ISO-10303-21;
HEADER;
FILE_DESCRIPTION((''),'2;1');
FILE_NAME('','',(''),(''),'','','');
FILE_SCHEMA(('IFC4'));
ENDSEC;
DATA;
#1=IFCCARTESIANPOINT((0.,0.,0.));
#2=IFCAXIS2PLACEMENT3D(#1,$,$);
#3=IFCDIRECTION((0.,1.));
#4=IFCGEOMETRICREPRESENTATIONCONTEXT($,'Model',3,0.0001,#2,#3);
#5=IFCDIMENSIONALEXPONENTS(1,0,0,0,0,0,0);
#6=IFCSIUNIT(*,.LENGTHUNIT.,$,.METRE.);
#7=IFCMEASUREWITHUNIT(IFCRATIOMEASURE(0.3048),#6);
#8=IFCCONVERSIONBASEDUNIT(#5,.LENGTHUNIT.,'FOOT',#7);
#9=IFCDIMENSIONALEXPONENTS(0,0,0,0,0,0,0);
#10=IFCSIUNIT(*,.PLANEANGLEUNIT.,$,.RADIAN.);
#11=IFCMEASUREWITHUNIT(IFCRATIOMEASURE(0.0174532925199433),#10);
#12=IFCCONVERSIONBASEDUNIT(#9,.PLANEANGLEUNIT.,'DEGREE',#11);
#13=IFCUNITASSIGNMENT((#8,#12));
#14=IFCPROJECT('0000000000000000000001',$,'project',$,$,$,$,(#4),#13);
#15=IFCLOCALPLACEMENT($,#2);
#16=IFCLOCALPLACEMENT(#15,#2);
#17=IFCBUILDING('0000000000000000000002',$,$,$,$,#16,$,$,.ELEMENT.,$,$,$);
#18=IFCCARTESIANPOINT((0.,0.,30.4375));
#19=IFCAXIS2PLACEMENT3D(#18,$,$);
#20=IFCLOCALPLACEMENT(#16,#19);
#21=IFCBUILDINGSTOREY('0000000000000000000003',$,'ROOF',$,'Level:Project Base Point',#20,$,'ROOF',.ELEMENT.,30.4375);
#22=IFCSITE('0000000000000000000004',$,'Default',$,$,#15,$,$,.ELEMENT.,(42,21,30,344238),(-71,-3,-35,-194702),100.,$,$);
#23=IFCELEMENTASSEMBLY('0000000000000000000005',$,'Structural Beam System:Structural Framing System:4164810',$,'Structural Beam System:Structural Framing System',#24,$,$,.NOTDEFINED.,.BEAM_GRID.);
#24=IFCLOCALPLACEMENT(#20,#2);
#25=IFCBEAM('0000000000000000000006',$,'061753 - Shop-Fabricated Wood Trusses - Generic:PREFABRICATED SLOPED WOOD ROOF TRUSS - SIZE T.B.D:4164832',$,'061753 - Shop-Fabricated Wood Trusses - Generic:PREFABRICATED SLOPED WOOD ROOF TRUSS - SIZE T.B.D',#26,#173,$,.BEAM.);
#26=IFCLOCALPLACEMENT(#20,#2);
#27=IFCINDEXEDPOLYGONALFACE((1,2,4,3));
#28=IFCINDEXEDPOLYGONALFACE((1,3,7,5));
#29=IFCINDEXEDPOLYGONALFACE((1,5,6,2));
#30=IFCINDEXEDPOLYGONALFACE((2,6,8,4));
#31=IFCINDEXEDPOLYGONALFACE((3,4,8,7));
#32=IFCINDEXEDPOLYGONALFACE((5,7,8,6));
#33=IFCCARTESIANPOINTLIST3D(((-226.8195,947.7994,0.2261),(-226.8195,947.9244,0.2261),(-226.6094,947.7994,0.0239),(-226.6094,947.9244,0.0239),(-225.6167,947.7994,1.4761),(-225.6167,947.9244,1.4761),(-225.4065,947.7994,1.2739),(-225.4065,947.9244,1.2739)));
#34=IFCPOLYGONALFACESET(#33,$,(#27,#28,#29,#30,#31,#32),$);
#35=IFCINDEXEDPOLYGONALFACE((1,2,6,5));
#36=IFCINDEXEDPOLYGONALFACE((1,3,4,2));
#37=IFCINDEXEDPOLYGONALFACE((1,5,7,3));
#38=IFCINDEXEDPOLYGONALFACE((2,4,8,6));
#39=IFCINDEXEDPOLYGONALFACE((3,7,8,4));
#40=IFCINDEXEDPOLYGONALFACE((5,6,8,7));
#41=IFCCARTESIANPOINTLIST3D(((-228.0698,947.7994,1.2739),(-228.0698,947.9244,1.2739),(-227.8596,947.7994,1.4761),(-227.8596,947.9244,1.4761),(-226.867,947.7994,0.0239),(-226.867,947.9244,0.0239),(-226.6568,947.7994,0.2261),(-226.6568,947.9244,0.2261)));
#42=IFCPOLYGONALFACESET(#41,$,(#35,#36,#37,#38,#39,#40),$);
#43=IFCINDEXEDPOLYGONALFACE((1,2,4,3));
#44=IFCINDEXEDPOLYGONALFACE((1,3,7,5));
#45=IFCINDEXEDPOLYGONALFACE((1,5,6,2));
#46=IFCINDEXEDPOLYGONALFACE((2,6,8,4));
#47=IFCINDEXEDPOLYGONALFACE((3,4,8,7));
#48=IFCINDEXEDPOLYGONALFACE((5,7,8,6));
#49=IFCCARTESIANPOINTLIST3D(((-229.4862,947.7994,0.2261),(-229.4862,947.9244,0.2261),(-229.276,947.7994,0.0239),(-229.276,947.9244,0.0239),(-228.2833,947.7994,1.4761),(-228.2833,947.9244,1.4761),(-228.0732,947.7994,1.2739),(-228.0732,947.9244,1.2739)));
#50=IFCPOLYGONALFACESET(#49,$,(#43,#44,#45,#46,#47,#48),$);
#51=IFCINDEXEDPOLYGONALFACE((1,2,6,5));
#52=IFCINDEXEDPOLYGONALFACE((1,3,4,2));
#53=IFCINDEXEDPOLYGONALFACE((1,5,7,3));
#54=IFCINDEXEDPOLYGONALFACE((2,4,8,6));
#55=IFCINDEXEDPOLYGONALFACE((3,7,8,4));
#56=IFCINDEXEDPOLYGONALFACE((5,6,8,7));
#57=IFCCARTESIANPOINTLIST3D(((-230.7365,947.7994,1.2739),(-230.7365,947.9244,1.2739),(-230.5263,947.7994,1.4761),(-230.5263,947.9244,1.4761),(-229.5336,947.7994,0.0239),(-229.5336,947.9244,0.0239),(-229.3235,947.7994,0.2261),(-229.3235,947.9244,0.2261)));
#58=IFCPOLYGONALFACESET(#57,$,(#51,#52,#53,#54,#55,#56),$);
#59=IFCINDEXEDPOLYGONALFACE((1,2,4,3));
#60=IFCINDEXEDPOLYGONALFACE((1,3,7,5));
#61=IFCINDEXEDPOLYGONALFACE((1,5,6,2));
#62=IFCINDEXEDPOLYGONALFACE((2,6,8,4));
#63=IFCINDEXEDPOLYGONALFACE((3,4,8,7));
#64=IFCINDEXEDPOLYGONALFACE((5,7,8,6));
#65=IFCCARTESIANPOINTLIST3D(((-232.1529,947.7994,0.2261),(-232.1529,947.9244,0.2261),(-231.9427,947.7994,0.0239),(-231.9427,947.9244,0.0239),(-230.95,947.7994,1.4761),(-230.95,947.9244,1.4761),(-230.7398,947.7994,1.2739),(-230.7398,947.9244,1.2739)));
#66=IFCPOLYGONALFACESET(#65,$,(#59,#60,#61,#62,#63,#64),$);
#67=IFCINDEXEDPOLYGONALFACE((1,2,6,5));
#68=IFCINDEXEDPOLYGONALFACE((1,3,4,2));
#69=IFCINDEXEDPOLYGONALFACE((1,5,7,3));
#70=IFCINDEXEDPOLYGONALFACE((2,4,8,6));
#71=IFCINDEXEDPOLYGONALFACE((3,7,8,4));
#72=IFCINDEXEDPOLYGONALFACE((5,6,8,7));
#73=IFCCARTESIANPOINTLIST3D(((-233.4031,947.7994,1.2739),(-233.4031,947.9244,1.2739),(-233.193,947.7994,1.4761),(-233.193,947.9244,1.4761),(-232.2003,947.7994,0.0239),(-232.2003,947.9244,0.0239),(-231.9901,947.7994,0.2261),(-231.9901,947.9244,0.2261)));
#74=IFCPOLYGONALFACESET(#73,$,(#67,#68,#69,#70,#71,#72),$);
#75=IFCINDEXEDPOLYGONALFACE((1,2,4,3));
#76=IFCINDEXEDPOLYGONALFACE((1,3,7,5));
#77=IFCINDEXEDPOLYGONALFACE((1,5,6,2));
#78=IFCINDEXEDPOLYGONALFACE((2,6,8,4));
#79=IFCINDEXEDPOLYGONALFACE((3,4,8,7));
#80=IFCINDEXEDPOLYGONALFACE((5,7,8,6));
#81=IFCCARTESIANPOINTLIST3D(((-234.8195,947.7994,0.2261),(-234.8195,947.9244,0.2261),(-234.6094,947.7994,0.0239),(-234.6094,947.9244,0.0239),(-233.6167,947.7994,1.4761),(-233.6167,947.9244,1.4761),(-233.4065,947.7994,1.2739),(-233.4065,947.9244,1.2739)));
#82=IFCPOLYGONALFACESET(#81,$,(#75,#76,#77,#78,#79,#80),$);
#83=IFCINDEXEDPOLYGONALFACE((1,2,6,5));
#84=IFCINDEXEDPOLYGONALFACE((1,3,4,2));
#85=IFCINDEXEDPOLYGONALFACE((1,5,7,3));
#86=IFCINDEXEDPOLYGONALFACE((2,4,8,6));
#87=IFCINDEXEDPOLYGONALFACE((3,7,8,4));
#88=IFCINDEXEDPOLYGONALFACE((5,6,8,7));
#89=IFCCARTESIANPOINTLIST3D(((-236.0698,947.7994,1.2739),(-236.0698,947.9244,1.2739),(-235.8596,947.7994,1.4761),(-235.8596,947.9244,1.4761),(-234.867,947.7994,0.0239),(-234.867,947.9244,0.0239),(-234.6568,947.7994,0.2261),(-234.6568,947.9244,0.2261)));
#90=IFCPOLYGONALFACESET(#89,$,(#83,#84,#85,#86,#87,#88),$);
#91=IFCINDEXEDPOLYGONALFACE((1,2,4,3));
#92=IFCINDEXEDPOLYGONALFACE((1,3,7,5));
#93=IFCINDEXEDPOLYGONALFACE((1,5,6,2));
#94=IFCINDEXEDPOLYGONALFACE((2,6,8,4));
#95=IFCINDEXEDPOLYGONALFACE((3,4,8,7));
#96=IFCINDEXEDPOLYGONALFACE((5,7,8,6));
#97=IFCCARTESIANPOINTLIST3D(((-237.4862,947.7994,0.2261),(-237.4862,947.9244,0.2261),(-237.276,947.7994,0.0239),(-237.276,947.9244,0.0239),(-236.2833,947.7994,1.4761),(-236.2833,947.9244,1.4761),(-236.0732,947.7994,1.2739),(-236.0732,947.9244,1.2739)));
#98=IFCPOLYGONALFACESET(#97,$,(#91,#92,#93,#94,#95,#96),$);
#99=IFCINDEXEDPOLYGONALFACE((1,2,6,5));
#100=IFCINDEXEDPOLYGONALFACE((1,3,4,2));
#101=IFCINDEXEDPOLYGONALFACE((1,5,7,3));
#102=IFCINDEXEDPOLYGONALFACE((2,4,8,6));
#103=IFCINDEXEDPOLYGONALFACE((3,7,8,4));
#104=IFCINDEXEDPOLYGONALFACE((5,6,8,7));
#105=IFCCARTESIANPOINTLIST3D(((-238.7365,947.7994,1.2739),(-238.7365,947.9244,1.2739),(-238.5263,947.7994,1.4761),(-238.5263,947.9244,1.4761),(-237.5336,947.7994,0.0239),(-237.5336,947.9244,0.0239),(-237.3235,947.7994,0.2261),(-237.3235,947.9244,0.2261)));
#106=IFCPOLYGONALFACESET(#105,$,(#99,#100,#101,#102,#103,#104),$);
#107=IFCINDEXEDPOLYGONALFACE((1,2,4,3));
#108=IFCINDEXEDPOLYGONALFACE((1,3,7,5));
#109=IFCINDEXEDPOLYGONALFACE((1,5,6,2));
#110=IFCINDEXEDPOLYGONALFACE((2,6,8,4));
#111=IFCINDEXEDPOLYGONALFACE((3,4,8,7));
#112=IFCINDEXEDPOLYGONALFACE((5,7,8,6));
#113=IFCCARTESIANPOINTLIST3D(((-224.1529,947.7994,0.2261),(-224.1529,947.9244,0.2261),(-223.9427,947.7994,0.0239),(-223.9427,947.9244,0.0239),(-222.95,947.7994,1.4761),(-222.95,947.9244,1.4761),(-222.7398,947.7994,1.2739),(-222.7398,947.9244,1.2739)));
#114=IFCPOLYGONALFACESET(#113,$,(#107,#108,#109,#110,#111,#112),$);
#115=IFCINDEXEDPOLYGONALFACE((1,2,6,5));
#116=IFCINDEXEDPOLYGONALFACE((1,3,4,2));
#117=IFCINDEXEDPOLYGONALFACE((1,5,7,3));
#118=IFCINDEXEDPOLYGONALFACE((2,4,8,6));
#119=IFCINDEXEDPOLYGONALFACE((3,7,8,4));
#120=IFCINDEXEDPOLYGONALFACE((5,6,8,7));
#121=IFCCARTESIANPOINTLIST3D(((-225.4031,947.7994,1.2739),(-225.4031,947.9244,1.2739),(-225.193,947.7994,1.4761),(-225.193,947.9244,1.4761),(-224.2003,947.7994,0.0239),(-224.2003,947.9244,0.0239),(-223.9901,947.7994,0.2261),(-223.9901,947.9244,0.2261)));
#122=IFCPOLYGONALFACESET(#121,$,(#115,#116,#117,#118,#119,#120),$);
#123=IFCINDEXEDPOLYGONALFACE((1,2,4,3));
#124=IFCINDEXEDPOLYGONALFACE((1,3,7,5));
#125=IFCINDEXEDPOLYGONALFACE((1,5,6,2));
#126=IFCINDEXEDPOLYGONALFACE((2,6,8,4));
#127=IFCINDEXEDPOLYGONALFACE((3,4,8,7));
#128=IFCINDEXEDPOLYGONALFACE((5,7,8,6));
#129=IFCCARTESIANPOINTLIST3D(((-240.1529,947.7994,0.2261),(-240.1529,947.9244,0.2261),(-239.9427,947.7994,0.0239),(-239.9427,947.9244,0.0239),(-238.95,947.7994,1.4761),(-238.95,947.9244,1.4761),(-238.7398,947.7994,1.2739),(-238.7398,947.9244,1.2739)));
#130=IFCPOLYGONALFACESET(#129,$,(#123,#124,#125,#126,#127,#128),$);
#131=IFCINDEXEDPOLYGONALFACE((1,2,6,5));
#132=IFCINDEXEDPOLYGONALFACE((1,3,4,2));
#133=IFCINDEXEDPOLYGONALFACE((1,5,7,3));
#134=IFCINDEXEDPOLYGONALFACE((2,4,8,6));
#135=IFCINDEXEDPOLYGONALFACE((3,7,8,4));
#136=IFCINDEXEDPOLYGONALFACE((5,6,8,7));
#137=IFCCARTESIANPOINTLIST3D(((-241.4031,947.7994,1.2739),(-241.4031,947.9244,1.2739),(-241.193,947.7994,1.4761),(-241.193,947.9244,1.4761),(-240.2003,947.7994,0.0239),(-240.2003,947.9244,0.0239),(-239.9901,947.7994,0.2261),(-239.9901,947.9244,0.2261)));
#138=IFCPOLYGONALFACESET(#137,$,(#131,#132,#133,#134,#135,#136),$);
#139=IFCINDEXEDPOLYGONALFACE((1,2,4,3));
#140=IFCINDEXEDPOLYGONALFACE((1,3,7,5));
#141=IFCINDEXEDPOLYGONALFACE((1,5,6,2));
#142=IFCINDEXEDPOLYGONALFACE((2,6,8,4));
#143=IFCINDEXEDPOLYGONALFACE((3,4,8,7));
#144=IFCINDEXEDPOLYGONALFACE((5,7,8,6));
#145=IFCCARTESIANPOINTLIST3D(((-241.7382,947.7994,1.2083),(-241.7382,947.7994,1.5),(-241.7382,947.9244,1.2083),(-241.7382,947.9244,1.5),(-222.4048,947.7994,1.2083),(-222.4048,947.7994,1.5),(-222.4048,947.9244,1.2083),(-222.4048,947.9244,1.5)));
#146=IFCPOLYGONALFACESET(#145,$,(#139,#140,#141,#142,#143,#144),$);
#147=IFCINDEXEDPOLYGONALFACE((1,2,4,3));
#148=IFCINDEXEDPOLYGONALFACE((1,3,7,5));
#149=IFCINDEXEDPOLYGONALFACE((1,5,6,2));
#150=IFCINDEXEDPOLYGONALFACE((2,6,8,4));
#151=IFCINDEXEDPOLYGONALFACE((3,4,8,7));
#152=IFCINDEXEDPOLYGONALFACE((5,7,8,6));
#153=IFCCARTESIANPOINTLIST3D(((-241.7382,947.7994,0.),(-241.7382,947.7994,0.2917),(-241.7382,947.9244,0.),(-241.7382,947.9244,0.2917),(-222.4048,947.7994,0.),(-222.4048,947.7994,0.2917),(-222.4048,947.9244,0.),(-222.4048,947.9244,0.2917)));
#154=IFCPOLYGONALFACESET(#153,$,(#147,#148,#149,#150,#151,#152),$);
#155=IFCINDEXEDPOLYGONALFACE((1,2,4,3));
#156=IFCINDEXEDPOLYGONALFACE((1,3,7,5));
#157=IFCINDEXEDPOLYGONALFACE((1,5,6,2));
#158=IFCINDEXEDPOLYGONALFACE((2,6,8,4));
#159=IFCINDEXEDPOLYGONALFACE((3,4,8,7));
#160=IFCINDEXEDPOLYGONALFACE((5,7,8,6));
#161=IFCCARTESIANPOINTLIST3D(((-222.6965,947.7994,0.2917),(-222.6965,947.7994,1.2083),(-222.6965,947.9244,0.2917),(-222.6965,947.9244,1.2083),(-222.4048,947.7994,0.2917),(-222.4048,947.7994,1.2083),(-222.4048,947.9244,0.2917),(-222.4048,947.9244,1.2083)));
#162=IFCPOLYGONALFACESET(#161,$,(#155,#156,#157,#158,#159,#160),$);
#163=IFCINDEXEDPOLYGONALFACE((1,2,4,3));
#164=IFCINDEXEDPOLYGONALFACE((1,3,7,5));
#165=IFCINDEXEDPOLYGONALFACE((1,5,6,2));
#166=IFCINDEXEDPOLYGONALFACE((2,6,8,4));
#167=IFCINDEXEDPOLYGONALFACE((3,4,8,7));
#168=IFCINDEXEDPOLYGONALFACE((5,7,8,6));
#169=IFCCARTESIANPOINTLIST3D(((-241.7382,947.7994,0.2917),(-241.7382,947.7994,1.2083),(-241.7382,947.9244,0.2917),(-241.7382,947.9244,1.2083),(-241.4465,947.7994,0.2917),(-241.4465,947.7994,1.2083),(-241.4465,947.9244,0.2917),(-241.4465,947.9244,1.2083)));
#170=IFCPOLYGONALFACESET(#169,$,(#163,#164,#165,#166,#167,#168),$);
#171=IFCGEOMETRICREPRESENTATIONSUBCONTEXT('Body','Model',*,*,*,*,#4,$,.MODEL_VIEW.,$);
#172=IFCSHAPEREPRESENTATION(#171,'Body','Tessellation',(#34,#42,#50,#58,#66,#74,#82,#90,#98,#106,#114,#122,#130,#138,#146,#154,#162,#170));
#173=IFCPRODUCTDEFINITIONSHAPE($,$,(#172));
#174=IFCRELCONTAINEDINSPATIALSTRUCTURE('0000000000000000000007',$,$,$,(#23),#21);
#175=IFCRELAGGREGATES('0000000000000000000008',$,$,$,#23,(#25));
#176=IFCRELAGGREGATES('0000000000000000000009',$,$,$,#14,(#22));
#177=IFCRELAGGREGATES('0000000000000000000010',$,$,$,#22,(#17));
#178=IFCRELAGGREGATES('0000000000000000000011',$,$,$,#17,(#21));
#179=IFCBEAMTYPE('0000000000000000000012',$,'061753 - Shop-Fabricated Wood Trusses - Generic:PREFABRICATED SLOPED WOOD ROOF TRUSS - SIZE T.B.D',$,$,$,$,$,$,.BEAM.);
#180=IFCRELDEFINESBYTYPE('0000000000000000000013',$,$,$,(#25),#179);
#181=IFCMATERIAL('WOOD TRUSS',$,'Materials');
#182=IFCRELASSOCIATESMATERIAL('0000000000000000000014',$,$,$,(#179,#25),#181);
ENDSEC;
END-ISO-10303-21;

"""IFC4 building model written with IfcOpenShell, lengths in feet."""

from ifc_helpers import new_model, entity, si_unit, converted_unit, direction, frame, frame_2d, origin, origin_2d_with_axis, place, context, subcontext, project, spatial, rectangle, extrude, source, transform, mapped, material, material_profile, profile_set, profile_usage, type_object, type_shapes, element, aggregate, save


model = new_model("IFC4")

# Units and contexts
model_context = context("Model", 3, precision=0.0001, world=origin(), true_north=direction((0.0, 1.0)))
body_context = subcontext(model_context, "Body", "Model", "MODEL_VIEW")
ifc_project = project(units=[converted_unit("LENGTHUNIT", "FOOT", entity("IfcRatioMeasure", 0.3048), si_unit("LENGTHUNIT", "METRE"), dimensions=[1, 0, 0, 0, 0, 0, 0]), converted_unit("PLANEANGLEUNIT", "DEGREE", entity("IfcRatioMeasure", 0.0174532925199433), si_unit("PLANEANGLEUNIT", "RADIAN"), dimensions=[0, 0, 0, 0, 0, 0, 0])], contexts=[model_context])

# Site, building, storey
site_placement = place(None, origin())
site = spatial("IfcSite", under=ifc_project, at=site_placement, Name="Default", CompositionType="ELEMENT", RefLatitude=(42, 21, 30, 344238), RefLongitude=(-71, -3, -35, -194702), RefElevation=100.0)
building_placement = place(site_placement, origin())
building = spatial("IfcBuilding", under=site, at=building_placement, CompositionType="ELEMENT")
storey_placement = place(building_placement, frame((0.0, 0.0, 30.4375)))
storey = spatial("IfcBuildingStorey", under=building, at=storey_placement, Name="ROOF", ObjectType="Level:Project Base Point", LongName="ROOF", CompositionType="ELEMENT", Elevation=30.4375)

# Element assembly, beam
assembly_1_placement = place(storey_placement, origin())
assembly_1 = element("IfcElementAssembly", 1, at=assembly_1_placement, inside=storey, Name="Structural Beam System:Structural Framing System:4164810", ObjectType="Structural Beam System:Structural Framing System", AssemblyPlace="NOTDEFINED", PredefinedType="BEAM_GRID")
ifc_material_1 = material(Name="WOOD TRUSS", Category="Materials")
ifc_material_profile_1 = material_profile(ifc_material_1, rectangle(XDim=1.7347, YDim=0.125, at=origin_2d_with_axis()), Name="PREFABRICATED SLOPED WOOD ROOF TRUSS - SIZE T.B.D")
ifc_material_profile_2 = material_profile(ifc_material_1, rectangle(XDim=1.7347, YDim=0.125, at=frame_2d((0.0, 0.0), x_axis=(1.0, 0.0))), Name="PREFABRICATED SLOPED WOOD ROOF TRUSS - SIZE T.B.D")
ifc_material_profile_3 = material_profile(ifc_material_1, rectangle(XDim=1.7347, YDim=0.125, at=origin_2d_with_axis()), Name="PREFABRICATED SLOPED WOOD ROOF TRUSS - SIZE T.B.D")
ifc_material_profile_4 = material_profile(ifc_material_1, rectangle(XDim=1.7347, YDim=0.125, at=origin_2d_with_axis()), Name="PREFABRICATED SLOPED WOOD ROOF TRUSS - SIZE T.B.D")
ifc_material_profile_5 = material_profile(ifc_material_1, rectangle(XDim=1.7347, YDim=0.125, at=frame_2d((0.0, 0.0), x_axis=(1.0, 0.0))), Name="PREFABRICATED SLOPED WOOD ROOF TRUSS - SIZE T.B.D")
ifc_material_profile_6 = material_profile(ifc_material_1, rectangle(XDim=1.7347, YDim=0.125, at=frame_2d((0.0, 0.0), x_axis=(1.0, 0.0))), Name="PREFABRICATED SLOPED WOOD ROOF TRUSS - SIZE T.B.D")
ifc_material_profile_7 = material_profile(ifc_material_1, rectangle(XDim=1.7347, YDim=0.125, at=frame_2d((0.0, 0.0), x_axis=(1.0, 0.0))), Name="PREFABRICATED SLOPED WOOD ROOF TRUSS - SIZE T.B.D")
ifc_material_profile_8 = material_profile(ifc_material_1, rectangle(XDim=1.7347, YDim=0.125, at=frame_2d((0.0, 0.0), x_axis=(1.0, 0.0))), Name="PREFABRICATED SLOPED WOOD ROOF TRUSS - SIZE T.B.D")
ifc_material_profile_9 = material_profile(ifc_material_1, rectangle(XDim=1.7347, YDim=0.125, at=origin_2d_with_axis()), Name="PREFABRICATED SLOPED WOOD ROOF TRUSS - SIZE T.B.D")
ifc_material_profile_10 = material_profile(ifc_material_1, rectangle(XDim=1.7347, YDim=0.125, at=frame_2d((0.0, 0.0), x_axis=(1.0, 0.0))), Name="PREFABRICATED SLOPED WOOD ROOF TRUSS - SIZE T.B.D")
ifc_material_profile_11 = material_profile(ifc_material_1, rectangle(XDim=0.2917, YDim=0.125, at=frame_2d((0.0, 0.0), x_axis=(1.0, 0.0))), Name="PREFABRICATED SLOPED WOOD ROOF TRUSS - SIZE T.B.D")
ifc_material_profile_12 = material_profile(ifc_material_1, rectangle(XDim=0.2917, YDim=0.125, at=frame_2d((0.0, 0.0), x_axis=(1.0, 0.0))), Name="PREFABRICATED SLOPED WOOD ROOF TRUSS - SIZE T.B.D")
ifc_material_profile_13 = material_profile(ifc_material_1, rectangle(XDim=0.9167, YDim=0.125, at=frame_2d((0.0, 0.0), x_axis=(1.0, 0.0))), Name="PREFABRICATED SLOPED WOOD ROOF TRUSS - SIZE T.B.D")
ifc_material_profile_14 = material_profile(ifc_material_1, rectangle(XDim=0.9167, YDim=0.125, at=frame_2d((0.0, 0.0), x_axis=(1.0, 0.0))), Name="PREFABRICATED SLOPED WOOD ROOF TRUSS - SIZE T.B.D")
ifc_profile_set_1 = profile_set([ifc_material_profile_1, ifc_material_profile_2, ifc_material_profile_3, ifc_material_profile_4, ifc_material_profile_5, ifc_material_profile_6, ifc_material_profile_7, ifc_material_profile_8, ifc_material_profile_9, ifc_material_profile_10, ifc_material_profile_11, ifc_material_profile_12, ifc_material_profile_13, ifc_material_profile_14], Name="PREFABRICATED SLOPED WOOD ROOF TRUSS - SIZE T.B.D")
beam_type_1 = type_object("IfcBeamType", Name="061753 - Shop-Fabricated Wood Trusses - Generic:PREFABRICATED SLOPED WOOD ROOF TRUSS - SIZE T.B.D", PredefinedType="BEAM", material=ifc_profile_set_1)
shared_shape_1 = source(origin(), body_context, "Body", "SweptSolid", [
    extrude(rectangle(XDim=1.7347, YDim=0.125, at=frame_2d((0.0, 0.0), x_axis=(1.0, 0.0))), frame((5.8534, 0.0, 0.1011), z_axis=(0.720569, 0.0, -0.693383), x_axis=(0.693383, 0.0, 0.720569)), (0.0, 0.0, 1.0), 0.2917),
    extrude(rectangle(XDim=1.7347, YDim=0.125, at=frame_2d((0.0, 0.0), x_axis=(1.0, 0.0))), frame((4.6031, 0.0, -0.1011), z_axis=(0.720569, 0.0, 0.693383), x_axis=(0.693383, 0.0, -0.720569)), (0.0, 0.0, 1.0), 0.2917),
    extrude(rectangle(XDim=1.7347, YDim=0.125, at=frame_2d((0.0, 0.0), x_axis=(1.0, 0.0))), frame((3.1867, 0.0, 0.1011), z_axis=(0.720569, 0.0, -0.693383), x_axis=(0.693383, 0.0, 0.720569)), (0.0, 0.0, 1.0), 0.2917),
    extrude(rectangle(XDim=1.7347, YDim=0.125, at=frame_2d((0.0, 0.0), x_axis=(1.0, 0.0))), frame((1.9364, 0.0, -0.1011), z_axis=(0.720569, 0.0, 0.693383), x_axis=(0.693383, 0.0, -0.720569)), (0.0, 0.0, 1.0), 0.2917),
    extrude(rectangle(XDim=1.7347, YDim=0.125, at=frame_2d((0.0, 0.0), x_axis=(1.0, 0.0))), frame((0.5201, 0.0, 0.1011), z_axis=(0.720569, 0.0, -0.693383), x_axis=(0.693383, 0.0, 0.720569)), (0.0, 0.0, 1.0), 0.2917),
    extrude(rectangle(XDim=1.7347, YDim=0.125, at=origin_2d_with_axis()), frame((-0.7302, 0.0, -0.1011), z_axis=(0.720569, 0.0, 0.693383), x_axis=(0.693383, 0.0, -0.720569)), (0.0, 0.0, 1.0), 0.2917),
    extrude(rectangle(XDim=1.7347, YDim=0.125, at=frame_2d((0.0, 0.0), x_axis=(1.0, 0.0))), frame((-2.1466, 0.0, 0.1011), z_axis=(0.720569, 0.0, -0.693383), x_axis=(0.693383, 0.0, 0.720569)), (0.0, 0.0, 1.0), 0.2917),
    extrude(rectangle(XDim=1.7347, YDim=0.125, at=frame_2d((0.0, 0.0), x_axis=(1.0, 0.0))), frame((-3.3969, 0.0, -0.1011), z_axis=(0.720569, 0.0, 0.693383), x_axis=(0.693383, 0.0, -0.720569)), (0.0, 0.0, 1.0), 0.2917),
    extrude(rectangle(XDim=1.7347, YDim=0.125, at=origin_2d_with_axis()), frame((-4.8133, 0.0, 0.1011), z_axis=(0.720569, 0.0, -0.693383), x_axis=(0.693383, 0.0, 0.720569)), (0.0, 0.0, 1.0), 0.2917),
    extrude(rectangle(XDim=1.7347, YDim=0.125, at=frame_2d((0.0, 0.0), x_axis=(1.0, 0.0))), frame((-6.0636, 0.0, -0.1011), z_axis=(0.720569, 0.0, 0.693383), x_axis=(0.693383, 0.0, -0.720569)), (0.0, 0.0, 1.0), 0.2917),
    extrude(rectangle(XDim=1.7347, YDim=0.125, at=frame_2d((0.0, 0.0), x_axis=(1.0, 0.0))), frame((8.5201, 0.0, 0.1011), z_axis=(0.720569, 0.0, -0.693383), x_axis=(0.693383, 0.0, 0.720569)), (0.0, 0.0, 1.0), 0.2917),
    extrude(rectangle(XDim=1.7347, YDim=0.125, at=origin_2d_with_axis()), frame((7.2698, 0.0, -0.1011), z_axis=(0.720569, 0.0, 0.693383), x_axis=(0.693383, 0.0, -0.720569)), (0.0, 0.0, 1.0), 0.2917),
    extrude(rectangle(XDim=1.7347, YDim=0.125, at=frame_2d((0.0, 0.0), x_axis=(1.0, 0.0))), frame((-7.4799, 0.0, 0.1011), z_axis=(0.720569, 0.0, -0.693383), x_axis=(0.693383, 0.0, 0.720569)), (0.0, 0.0, 1.0), 0.2917),
    extrude(rectangle(XDim=1.7347, YDim=0.125, at=origin_2d_with_axis()), frame((-8.7302, 0.0, -0.1011), z_axis=(0.720569, 0.0, 0.693383), x_axis=(0.693383, 0.0, -0.720569)), (0.0, 0.0, 1.0), 0.2917),
    extrude(rectangle(XDim=0.2917, YDim=0.125, at=frame_2d((0.0, 0.0), x_axis=(1.0, 0.0))), frame((-9.6667, 0.0, 0.6042), z_axis=(1.0, 0.0, 0.0), x_axis=(0.0, 0.0, -1.0)), (0.0, 0.0, 1.0), 19.3333),
    extrude(rectangle(XDim=0.2917, YDim=0.125, at=frame_2d((0.0, 0.0), x_axis=(1.0, 0.0))), frame((-9.6667, 0.0, -0.6042), z_axis=(1.0, 0.0, 0.0), x_axis=(0.0, 0.0, -1.0)), (0.0, 0.0, 1.0), 19.3333),
    extrude(rectangle(XDim=0.9167, YDim=0.125, at=frame_2d((0.0, 0.0), x_axis=(1.0, 0.0))), frame((9.375, 0.0, 0.0), z_axis=(1.0, 0.0, 0.0), x_axis=(0.0, 0.0, -1.0)), (0.0, 0.0, 1.0), 0.2917),
    extrude(rectangle(XDim=0.9167, YDim=0.125, at=frame_2d((0.0, 0.0), x_axis=(1.0, 0.0))), frame((-9.6667, 0.0, 0.0), z_axis=(1.0, 0.0, 0.0), x_axis=(0.0, 0.0, -1.0)), (0.0, 0.0, 1.0), 0.2917),
])
type_shapes(beam_type_1, [shared_shape_1])
ifc_profile_usage_1 = profile_usage(ifc_profile_set_1, cardinal=8)
beam_1_placement = place(assembly_1_placement, frame((-232.0715, 947.8619, 0.75)))
beam_1 = element("IfcBeam", 2, at=beam_1_placement, type_object=beam_type_1, material=ifc_profile_usage_1, Name="061753 - Shop-Fabricated Wood Trusses - Generic:PREFABRICATED SLOPED WOOD ROOF TRUSS - SIZE T.B.D:4164832", ObjectType="061753 - Shop-Fabricated Wood Trusses - Generic:PREFABRICATED SLOPED WOOD ROOF TRUSS - SIZE T.B.D", PredefinedType="BEAM", context=body_context, shape_type="MappedRepresentation", body=[
    mapped(shared_shape_1, transform((0.0, 0.0, 0.0), scale=1.0)),
])
aggregate(assembly_1, [beam_1])

save(model, "model.ifc")
